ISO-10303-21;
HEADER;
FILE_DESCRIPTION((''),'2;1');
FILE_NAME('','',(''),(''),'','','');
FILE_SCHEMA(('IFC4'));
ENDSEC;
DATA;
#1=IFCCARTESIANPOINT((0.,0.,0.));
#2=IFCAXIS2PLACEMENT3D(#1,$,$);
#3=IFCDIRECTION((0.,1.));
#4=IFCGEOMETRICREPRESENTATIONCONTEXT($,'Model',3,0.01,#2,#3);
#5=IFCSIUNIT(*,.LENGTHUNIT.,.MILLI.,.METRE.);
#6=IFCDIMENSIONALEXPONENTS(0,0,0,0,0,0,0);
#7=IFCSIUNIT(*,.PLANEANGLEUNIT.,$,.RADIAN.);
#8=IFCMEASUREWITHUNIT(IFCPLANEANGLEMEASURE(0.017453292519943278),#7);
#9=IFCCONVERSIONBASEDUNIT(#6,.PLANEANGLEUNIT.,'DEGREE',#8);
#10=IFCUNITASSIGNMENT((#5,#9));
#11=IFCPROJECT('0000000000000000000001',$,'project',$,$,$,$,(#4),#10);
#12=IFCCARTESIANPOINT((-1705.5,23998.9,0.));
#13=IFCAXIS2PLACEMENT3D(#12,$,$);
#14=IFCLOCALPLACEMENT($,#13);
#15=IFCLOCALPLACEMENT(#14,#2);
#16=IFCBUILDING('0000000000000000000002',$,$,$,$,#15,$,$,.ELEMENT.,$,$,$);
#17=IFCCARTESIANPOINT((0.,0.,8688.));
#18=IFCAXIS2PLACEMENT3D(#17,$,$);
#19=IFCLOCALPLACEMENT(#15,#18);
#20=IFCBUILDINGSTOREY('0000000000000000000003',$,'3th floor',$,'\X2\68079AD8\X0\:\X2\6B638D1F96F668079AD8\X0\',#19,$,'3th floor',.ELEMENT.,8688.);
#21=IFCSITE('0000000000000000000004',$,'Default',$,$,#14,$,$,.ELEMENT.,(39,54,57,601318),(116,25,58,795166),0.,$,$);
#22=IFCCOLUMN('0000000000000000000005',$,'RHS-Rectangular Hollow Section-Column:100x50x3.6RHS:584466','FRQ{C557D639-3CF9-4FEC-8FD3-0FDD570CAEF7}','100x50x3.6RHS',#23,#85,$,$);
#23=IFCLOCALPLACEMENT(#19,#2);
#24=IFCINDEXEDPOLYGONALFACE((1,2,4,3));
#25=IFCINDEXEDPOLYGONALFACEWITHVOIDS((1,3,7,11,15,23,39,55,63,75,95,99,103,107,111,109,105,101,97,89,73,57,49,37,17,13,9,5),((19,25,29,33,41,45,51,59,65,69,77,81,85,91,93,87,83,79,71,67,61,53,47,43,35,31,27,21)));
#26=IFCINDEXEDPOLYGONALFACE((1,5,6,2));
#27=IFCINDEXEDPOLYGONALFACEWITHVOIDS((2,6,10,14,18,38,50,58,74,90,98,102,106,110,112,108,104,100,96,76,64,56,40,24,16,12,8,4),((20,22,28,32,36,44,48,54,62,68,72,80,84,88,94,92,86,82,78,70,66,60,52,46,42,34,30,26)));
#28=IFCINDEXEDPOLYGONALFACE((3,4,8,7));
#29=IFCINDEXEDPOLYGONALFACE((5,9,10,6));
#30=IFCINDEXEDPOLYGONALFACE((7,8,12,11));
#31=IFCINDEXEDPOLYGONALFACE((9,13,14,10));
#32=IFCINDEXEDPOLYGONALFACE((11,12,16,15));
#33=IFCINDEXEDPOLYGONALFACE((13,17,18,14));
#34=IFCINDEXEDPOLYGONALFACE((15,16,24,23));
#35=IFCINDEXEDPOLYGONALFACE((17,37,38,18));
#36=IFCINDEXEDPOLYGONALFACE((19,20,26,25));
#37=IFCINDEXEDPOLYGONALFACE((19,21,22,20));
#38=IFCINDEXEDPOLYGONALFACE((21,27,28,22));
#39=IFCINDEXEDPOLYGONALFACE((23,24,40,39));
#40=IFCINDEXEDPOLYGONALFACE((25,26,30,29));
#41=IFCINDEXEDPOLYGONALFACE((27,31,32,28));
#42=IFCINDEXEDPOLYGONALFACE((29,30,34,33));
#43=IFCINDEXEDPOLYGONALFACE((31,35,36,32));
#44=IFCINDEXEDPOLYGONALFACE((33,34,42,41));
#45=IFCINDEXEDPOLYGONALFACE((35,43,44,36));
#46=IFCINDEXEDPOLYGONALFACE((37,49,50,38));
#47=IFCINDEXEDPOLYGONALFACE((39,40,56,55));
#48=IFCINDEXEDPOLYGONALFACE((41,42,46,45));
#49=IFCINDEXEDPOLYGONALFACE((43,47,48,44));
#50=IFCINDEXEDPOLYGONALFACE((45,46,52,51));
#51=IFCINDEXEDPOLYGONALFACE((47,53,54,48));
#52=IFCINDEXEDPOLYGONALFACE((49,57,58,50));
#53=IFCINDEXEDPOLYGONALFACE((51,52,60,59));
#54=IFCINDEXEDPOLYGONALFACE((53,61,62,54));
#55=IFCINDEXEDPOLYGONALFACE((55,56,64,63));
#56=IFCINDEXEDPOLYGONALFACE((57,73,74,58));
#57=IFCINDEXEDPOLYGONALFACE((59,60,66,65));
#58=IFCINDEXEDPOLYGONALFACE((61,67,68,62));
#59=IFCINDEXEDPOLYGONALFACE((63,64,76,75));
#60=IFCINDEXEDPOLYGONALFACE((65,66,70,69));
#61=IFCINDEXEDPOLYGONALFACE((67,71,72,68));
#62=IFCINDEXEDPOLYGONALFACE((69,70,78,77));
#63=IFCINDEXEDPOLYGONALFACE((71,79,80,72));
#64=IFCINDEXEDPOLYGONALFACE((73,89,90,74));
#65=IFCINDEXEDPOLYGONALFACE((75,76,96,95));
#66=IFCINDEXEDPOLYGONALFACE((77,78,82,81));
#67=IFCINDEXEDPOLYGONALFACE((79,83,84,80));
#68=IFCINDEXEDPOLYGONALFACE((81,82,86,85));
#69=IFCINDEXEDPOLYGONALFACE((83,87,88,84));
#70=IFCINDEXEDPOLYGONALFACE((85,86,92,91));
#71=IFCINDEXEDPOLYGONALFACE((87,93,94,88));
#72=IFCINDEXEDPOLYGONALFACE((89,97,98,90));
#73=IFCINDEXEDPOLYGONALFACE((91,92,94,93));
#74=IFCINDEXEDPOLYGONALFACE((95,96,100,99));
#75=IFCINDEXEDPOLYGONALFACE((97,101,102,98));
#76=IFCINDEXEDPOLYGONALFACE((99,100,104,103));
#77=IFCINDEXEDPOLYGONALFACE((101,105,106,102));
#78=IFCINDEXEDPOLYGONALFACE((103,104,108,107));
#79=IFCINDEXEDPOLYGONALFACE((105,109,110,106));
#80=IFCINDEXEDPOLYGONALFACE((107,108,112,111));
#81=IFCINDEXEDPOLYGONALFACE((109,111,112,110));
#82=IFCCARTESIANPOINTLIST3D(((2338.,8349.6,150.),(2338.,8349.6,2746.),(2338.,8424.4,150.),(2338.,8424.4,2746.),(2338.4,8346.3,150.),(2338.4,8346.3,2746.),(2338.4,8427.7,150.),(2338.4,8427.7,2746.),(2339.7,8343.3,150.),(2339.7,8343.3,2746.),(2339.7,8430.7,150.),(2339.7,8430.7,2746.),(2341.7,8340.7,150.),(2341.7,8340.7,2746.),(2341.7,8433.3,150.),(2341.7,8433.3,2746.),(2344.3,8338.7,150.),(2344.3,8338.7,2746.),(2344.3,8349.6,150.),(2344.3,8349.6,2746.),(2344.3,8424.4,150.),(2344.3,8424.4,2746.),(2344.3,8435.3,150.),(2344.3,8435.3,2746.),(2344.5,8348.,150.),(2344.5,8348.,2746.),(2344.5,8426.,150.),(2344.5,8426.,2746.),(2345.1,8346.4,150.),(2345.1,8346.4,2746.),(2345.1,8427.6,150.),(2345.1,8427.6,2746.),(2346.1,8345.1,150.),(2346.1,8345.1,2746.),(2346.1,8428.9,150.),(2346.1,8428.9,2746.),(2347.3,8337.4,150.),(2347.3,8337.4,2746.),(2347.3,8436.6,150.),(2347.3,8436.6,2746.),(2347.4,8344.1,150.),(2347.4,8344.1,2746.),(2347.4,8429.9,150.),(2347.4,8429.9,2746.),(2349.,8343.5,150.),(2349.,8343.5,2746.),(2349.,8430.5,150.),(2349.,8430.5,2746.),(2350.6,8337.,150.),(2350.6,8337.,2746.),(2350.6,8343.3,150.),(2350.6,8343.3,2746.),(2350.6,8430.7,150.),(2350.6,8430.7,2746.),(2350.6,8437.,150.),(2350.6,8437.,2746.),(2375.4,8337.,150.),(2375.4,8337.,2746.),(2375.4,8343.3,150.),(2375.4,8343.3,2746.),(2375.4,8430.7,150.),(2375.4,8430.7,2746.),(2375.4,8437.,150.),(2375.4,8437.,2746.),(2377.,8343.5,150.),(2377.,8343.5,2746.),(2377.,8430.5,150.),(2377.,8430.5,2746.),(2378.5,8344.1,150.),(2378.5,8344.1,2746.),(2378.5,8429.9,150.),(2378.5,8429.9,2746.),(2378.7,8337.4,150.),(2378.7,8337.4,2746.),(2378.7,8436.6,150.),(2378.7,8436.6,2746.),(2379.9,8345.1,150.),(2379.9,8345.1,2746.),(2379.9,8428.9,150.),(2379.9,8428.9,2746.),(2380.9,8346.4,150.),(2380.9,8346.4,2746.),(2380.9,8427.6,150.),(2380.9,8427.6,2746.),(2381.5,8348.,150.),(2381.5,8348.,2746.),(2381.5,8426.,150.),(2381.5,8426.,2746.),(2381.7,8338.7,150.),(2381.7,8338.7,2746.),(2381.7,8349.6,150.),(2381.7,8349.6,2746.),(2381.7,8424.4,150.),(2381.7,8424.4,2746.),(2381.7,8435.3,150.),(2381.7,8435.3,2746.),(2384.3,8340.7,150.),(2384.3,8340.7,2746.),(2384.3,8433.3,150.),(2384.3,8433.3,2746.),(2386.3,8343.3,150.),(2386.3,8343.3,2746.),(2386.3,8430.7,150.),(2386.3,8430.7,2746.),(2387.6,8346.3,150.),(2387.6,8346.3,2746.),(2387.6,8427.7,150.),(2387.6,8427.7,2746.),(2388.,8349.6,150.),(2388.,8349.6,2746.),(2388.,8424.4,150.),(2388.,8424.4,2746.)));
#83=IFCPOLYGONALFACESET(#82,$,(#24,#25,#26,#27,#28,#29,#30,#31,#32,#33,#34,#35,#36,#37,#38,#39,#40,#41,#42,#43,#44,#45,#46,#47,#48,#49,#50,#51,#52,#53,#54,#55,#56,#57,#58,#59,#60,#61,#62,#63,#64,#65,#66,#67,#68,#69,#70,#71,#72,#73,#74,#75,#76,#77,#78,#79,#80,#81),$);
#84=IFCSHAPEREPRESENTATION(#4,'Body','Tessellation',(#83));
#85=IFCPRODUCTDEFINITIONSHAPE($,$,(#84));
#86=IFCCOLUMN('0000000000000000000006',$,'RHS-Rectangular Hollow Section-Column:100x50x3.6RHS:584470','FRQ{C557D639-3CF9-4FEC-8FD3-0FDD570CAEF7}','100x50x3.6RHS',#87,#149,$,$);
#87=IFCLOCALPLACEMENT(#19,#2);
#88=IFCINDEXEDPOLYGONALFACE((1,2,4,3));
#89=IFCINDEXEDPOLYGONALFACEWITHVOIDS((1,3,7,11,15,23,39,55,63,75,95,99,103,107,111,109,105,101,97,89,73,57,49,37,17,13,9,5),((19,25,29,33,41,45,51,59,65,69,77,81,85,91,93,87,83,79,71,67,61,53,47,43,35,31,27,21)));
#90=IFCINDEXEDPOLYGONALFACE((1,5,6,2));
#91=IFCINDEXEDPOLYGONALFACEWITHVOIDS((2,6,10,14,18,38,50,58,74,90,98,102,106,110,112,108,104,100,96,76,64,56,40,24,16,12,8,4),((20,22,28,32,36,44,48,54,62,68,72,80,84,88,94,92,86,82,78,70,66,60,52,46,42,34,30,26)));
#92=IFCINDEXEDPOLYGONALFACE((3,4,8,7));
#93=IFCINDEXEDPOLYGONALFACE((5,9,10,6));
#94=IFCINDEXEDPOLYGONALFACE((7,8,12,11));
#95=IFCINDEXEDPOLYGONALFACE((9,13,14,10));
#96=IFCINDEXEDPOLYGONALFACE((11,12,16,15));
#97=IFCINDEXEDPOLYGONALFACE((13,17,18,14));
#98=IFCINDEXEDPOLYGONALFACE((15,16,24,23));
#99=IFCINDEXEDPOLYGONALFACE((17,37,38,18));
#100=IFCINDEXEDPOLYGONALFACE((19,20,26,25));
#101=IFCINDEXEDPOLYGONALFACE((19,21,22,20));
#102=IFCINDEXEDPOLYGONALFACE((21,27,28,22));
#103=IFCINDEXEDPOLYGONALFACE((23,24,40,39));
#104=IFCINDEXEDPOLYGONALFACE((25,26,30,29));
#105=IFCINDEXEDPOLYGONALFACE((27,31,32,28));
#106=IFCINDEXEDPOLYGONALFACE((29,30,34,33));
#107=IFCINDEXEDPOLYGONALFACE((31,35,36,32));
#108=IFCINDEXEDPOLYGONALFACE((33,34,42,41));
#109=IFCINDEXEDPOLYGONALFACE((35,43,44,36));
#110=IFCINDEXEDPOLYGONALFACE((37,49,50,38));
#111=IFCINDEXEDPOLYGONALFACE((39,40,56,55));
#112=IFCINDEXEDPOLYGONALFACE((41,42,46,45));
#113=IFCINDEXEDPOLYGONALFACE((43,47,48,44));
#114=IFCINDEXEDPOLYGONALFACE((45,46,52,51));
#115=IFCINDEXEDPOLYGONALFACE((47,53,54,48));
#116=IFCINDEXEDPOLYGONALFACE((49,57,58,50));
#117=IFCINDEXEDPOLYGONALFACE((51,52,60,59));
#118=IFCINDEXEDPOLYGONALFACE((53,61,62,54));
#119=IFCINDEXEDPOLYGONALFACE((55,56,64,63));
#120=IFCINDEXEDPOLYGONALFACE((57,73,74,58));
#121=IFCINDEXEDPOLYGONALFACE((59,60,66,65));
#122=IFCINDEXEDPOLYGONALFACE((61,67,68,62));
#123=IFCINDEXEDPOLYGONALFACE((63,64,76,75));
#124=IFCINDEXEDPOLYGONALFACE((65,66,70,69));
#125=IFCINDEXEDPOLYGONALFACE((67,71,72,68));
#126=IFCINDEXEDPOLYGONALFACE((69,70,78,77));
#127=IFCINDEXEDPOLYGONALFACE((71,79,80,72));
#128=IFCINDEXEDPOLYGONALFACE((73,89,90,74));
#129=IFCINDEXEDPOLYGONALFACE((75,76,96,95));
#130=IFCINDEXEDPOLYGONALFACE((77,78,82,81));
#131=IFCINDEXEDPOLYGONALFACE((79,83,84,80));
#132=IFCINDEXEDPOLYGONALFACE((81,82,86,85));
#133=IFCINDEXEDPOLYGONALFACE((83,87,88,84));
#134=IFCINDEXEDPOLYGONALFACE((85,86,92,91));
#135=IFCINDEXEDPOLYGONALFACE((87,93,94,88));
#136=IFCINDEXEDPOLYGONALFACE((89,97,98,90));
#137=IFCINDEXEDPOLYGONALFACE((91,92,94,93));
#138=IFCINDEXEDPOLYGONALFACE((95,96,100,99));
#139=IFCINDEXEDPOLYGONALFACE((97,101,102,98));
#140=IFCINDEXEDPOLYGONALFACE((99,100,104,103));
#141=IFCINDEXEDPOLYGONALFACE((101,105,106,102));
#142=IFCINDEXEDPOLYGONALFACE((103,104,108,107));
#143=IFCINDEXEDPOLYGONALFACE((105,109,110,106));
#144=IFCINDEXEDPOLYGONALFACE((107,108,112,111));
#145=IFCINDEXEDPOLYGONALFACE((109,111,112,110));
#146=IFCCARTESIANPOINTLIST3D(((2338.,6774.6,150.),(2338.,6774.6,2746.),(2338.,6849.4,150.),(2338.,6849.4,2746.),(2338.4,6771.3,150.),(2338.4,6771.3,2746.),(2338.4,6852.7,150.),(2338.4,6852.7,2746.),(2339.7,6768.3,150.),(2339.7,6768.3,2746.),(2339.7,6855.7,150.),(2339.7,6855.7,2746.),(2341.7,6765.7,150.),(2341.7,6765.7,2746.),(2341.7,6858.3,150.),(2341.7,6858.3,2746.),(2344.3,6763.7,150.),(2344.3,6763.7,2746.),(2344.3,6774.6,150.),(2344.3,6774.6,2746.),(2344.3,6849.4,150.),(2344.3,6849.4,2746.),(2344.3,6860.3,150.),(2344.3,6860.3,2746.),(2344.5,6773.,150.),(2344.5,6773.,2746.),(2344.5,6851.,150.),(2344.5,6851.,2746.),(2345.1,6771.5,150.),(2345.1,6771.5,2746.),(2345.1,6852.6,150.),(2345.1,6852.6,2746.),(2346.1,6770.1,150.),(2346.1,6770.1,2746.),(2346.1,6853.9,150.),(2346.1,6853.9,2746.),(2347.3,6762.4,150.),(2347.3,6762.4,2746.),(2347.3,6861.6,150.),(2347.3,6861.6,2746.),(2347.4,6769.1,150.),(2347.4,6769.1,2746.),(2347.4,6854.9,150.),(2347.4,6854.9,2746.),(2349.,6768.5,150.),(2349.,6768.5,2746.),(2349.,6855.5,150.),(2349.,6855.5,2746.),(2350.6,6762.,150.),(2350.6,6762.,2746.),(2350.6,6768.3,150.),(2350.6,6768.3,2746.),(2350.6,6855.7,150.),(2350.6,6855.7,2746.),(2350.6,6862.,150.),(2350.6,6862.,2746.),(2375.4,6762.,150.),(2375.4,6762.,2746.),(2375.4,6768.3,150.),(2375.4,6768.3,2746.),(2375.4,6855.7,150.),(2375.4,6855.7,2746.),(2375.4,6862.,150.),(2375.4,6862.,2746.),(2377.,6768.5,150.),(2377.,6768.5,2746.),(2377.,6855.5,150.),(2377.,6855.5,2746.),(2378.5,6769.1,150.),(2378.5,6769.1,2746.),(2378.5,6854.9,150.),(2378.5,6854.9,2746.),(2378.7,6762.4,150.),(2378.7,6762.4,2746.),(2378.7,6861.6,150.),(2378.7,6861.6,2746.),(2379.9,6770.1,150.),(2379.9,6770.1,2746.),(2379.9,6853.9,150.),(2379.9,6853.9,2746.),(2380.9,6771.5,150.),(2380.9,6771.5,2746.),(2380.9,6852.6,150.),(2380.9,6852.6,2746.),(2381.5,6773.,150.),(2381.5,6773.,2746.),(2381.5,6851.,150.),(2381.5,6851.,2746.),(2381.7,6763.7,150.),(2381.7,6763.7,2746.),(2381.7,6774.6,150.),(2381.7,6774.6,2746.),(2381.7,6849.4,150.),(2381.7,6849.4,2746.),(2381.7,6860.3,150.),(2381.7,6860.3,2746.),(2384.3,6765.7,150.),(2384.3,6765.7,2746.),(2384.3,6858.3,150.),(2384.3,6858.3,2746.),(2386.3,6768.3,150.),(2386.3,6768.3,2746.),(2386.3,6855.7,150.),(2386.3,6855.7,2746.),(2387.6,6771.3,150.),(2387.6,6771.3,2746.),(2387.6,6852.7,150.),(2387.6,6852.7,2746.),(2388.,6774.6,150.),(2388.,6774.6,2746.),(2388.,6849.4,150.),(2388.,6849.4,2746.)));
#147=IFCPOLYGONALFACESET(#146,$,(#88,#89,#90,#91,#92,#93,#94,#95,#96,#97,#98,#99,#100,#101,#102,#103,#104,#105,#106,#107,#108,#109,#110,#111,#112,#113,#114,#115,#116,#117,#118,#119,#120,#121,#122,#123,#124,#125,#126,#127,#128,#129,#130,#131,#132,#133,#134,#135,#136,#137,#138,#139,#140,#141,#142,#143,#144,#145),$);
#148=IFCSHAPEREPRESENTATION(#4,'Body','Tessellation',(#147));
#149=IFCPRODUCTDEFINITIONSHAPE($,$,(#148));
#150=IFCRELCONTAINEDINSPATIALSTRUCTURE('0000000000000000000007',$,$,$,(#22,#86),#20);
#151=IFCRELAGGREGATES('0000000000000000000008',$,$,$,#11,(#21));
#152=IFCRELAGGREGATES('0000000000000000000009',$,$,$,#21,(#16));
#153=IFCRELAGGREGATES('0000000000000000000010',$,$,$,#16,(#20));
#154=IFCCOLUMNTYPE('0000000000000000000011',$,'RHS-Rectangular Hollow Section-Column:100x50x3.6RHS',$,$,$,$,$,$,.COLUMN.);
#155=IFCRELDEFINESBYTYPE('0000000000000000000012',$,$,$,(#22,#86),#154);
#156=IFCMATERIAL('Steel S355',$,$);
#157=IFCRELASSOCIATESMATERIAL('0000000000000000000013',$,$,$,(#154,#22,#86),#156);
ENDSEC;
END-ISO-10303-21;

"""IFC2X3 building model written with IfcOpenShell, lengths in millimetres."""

from ifc_helpers import new_model, entity, si_unit, converted_unit, direction, frame, origin, origin_2d, place, context, project, spatial, hollow_rectangle, extrude, clip, halfspace, material, type_object, element, save


model = new_model("IFC2X3")

# Units and contexts
model_context = context("Model", 3, precision=0.01, world=origin(), true_north=direction((0.0, 1.0)))
ifc_project = project(units=[si_unit("LENGTHUNIT", "METRE", prefix="MILLI"), converted_unit("PLANEANGLEUNIT", "DEGREE", entity("IfcPlaneAngleMeasure", 0.017453292519943278), si_unit("PLANEANGLEUNIT", "RADIAN"), dimensions=[0, 0, 0, 0, 0, 0, 0])], contexts=[model_context])

# Site, building, storey
site_placement = place(None, frame((-1705.5, 23998.9, 0.0)))
site = spatial("IfcSite", under=ifc_project, at=site_placement, Name="Default", CompositionType="ELEMENT", RefLatitude=(39, 54, 57, 601318), RefLongitude=(116, 25, 58, 795166), RefElevation=0.0)
building_placement = place(site_placement, origin())
building = spatial("IfcBuilding", under=site, at=building_placement, CompositionType="ELEMENT")
storey_placement = place(building_placement, frame((0.0, 0.0, 8688.0)))
storey = spatial("IfcBuildingStorey", under=building, at=storey_placement, Name="3th floor", ObjectType="标高:正负零标高", LongName="3th floor", CompositionType="ELEMENT", Elevation=8688.0)

# Columns
ifc_material_1 = material(Name="Steel S355")
column_type_1 = type_object("IfcColumnType", Name="RHS-Rectangular Hollow Section-Column:100x50x3.6RHS", PredefinedType="COLUMN", material=ifc_material_1)
column_1_placement = place(storey_placement, frame((2363.0, 8387.0, 2746.0), z_axis=(0.0, 0.0, 1.0), x_axis=(-1.0, 0.0, 0.0)))
element("IfcColumn", 1, at=column_1_placement, inside=storey, type_object=column_type_1, material=ifc_material_1, Name="RHS-Rectangular Hollow Section-Column:100x50x3.6RHS:584466", Description="FRQ{C557D639-3CF9-4FEC-8FD3-0FDD570CAEF7}", ObjectType="100x50x3.6RHS", context=model_context, shape_type="Clipping", body=[
    clip(extrude(hollow_rectangle(XDim=50.0, YDim=100.0, WallThickness=6.3, InnerFilletRadius=6.3, OuterFilletRadius=12.6, at=origin_2d()), origin(), (0.0, 0.0, -1.0), 2651.9), halfspace(frame((2363.0, 8387.0, -2596.0), z_axis=(0.0, 0.0, 1.0), x_axis=(-1.0, 0.0, 0.0)), True)),
])
column_2_placement = place(storey_placement, frame((2363.0, 6812.0, 2746.0), z_axis=(0.0, 0.0, 1.0), x_axis=(-1.0, 0.0, 0.0)))
element("IfcColumn", 2, at=column_2_placement, inside=storey, type_object=column_type_1, material=ifc_material_1, Name="RHS-Rectangular Hollow Section-Column:100x50x3.6RHS:584470", Description="FRQ{C557D639-3CF9-4FEC-8FD3-0FDD570CAEF7}", ObjectType="100x50x3.6RHS", context=model_context, shape_type="Clipping", body=[
    clip(extrude(hollow_rectangle(XDim=50.0, YDim=100.0, WallThickness=6.3, InnerFilletRadius=6.3, OuterFilletRadius=12.6, at=origin_2d()), origin(), (0.0, 0.0, -1.0), 2651.9), halfspace(frame((2363.0, 6812.0, -2596.0), z_axis=(0.0, 0.0, 1.0), x_axis=(-1.0, 0.0, 0.0)), True)),
])

save(model, "model.ifc")
